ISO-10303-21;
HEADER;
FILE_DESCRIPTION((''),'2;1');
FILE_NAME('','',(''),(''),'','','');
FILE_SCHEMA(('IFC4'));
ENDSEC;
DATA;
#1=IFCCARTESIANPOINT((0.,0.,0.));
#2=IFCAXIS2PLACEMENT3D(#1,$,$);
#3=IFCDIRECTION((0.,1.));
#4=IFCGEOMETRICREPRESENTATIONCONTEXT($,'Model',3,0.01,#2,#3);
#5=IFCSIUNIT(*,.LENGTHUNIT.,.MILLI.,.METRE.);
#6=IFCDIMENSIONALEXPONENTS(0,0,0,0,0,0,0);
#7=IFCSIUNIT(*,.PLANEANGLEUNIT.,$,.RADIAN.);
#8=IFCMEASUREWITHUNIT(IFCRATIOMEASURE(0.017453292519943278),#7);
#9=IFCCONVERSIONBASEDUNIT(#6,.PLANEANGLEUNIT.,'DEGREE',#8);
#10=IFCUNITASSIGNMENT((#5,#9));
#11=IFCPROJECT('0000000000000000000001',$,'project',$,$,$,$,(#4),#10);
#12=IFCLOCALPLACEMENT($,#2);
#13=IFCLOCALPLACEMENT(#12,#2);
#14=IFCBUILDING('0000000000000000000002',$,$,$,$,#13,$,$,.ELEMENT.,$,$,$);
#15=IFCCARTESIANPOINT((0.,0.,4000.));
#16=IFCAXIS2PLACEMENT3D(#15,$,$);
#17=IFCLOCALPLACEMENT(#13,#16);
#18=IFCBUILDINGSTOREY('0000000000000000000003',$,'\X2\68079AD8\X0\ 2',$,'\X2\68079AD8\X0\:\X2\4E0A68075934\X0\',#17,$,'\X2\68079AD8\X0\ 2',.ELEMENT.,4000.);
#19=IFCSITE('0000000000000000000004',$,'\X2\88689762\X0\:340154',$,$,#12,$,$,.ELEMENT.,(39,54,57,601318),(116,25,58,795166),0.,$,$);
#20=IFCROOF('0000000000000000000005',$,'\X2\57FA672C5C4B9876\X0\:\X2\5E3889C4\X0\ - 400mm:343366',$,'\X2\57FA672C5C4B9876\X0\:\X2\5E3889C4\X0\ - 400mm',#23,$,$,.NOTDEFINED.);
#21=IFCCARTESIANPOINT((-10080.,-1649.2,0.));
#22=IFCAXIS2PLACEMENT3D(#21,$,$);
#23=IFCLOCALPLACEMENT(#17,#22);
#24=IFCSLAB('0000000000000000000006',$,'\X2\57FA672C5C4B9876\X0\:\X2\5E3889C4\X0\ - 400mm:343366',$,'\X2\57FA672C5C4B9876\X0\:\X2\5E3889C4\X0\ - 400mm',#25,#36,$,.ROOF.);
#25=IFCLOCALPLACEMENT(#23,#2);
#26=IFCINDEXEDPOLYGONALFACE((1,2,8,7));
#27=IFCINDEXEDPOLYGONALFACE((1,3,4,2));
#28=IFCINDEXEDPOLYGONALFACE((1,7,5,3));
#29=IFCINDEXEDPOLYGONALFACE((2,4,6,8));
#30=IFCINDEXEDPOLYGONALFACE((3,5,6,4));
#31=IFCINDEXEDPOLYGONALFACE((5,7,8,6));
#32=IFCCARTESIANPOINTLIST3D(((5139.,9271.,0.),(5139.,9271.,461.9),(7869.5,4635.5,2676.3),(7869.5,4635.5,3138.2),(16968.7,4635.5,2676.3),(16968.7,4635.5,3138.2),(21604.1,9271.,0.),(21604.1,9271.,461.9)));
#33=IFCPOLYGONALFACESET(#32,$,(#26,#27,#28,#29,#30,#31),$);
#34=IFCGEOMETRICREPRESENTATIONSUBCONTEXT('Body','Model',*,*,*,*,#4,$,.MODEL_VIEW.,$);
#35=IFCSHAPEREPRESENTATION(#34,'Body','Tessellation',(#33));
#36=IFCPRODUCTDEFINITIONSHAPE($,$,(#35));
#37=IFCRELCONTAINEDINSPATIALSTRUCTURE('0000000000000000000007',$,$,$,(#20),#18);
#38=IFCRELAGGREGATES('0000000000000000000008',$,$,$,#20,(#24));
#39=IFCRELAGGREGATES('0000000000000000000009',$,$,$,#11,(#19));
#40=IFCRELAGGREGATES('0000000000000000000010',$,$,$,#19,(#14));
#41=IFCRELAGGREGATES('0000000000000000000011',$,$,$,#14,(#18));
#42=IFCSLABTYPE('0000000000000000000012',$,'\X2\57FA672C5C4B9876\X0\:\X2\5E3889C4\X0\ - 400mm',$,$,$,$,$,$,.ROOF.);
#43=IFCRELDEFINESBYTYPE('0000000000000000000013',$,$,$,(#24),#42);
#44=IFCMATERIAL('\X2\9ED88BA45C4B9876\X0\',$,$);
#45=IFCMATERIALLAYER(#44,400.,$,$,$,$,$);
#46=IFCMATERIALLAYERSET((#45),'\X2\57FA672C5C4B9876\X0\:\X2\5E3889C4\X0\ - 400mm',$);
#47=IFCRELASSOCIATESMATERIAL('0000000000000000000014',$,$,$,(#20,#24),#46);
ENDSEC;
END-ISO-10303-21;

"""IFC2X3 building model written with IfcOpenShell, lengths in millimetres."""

from ifc_helpers import new_model, entity, si_unit, converted_unit, direction, frame, origin, place, context, subcontext, project, spatial, polyline, outline, extrude, material, layer, layer_set, type_object, element, aggregate, save


model = new_model("IFC2X3")

# Units and contexts
model_context = context("Model", 3, precision=0.01, world=origin(), true_north=direction((0.0, 1.0)))
body_context = subcontext(model_context, "Body", "Model", "MODEL_VIEW")
ifc_project = project(units=[si_unit("LENGTHUNIT", "METRE", prefix="MILLI"), converted_unit("PLANEANGLEUNIT", "DEGREE", entity("IfcRatioMeasure", 0.017453292519943278), si_unit("PLANEANGLEUNIT", "RADIAN"), dimensions=[0, 0, 0, 0, 0, 0, 0])], contexts=[model_context])

# Site, building, storey
site_placement = place(None, origin())
site = spatial("IfcSite", under=ifc_project, at=site_placement, Name="表面:340154", CompositionType="ELEMENT", RefLatitude=(39, 54, 57, 601318), RefLongitude=(116, 25, 58, 795166), RefElevation=0.0)
building_placement = place(site_placement, origin())
building = spatial("IfcBuilding", under=site, at=building_placement, CompositionType="ELEMENT")
storey_placement = place(building_placement, frame((0.0, 0.0, 4000.0)))
storey = spatial("IfcBuildingStorey", under=building, at=storey_placement, Name="标高 2", ObjectType="标高:上标头", LongName="标高 2", CompositionType="ELEMENT", Elevation=4000.0)

# Roof, slab
ifc_material = material(Name="默认屋顶")
ifc_layer = layer(ifc_material, 400.0)
ifc_layer_set = layer_set([ifc_layer], Name="基本屋顶:常规 - 400mm")
roof_placement = place(storey_placement, frame((-10080.0, -1649.2, 0.0)))
roof = element("IfcRoof", 1, at=roof_placement, inside=storey, material=ifc_layer_set, Name="基本屋顶:常规 - 400mm:343366", ObjectType="基本屋顶:常规 - 400mm", ShapeType="NOTDEFINED")
slab_type_1 = type_object("IfcSlabType", Name="基本屋顶:常规 - 400mm", PredefinedType="ROOF")
slab_1_placement = place(roof_placement, origin())
slab_1 = element("IfcSlab", 2, at=slab_1_placement, type_object=slab_type_1, material=ifc_layer_set, Name="基本屋顶:常规 - 400mm:343366", ObjectType="基本屋顶:常规 - 400mm", PredefinedType="ROOF", context=body_context, shape_type="SweptSolid", body=[
    extrude(outline(polyline([(-5502.1, -2676.3), (3597.1, -2676.3), (8232.6, 2676.3), (-8232.6, 2676.3), (-5502.1, -2676.3)])), frame((13371.6, 6953.2, 1338.1), z_axis=(0.0, 0.5, 0.866025), x_axis=(1.0, 0.0, 0.0)), (0.0, -0.5, 0.866025), 461.9),
])
aggregate(roof, [slab_1])

save(model, "model.ifc")
